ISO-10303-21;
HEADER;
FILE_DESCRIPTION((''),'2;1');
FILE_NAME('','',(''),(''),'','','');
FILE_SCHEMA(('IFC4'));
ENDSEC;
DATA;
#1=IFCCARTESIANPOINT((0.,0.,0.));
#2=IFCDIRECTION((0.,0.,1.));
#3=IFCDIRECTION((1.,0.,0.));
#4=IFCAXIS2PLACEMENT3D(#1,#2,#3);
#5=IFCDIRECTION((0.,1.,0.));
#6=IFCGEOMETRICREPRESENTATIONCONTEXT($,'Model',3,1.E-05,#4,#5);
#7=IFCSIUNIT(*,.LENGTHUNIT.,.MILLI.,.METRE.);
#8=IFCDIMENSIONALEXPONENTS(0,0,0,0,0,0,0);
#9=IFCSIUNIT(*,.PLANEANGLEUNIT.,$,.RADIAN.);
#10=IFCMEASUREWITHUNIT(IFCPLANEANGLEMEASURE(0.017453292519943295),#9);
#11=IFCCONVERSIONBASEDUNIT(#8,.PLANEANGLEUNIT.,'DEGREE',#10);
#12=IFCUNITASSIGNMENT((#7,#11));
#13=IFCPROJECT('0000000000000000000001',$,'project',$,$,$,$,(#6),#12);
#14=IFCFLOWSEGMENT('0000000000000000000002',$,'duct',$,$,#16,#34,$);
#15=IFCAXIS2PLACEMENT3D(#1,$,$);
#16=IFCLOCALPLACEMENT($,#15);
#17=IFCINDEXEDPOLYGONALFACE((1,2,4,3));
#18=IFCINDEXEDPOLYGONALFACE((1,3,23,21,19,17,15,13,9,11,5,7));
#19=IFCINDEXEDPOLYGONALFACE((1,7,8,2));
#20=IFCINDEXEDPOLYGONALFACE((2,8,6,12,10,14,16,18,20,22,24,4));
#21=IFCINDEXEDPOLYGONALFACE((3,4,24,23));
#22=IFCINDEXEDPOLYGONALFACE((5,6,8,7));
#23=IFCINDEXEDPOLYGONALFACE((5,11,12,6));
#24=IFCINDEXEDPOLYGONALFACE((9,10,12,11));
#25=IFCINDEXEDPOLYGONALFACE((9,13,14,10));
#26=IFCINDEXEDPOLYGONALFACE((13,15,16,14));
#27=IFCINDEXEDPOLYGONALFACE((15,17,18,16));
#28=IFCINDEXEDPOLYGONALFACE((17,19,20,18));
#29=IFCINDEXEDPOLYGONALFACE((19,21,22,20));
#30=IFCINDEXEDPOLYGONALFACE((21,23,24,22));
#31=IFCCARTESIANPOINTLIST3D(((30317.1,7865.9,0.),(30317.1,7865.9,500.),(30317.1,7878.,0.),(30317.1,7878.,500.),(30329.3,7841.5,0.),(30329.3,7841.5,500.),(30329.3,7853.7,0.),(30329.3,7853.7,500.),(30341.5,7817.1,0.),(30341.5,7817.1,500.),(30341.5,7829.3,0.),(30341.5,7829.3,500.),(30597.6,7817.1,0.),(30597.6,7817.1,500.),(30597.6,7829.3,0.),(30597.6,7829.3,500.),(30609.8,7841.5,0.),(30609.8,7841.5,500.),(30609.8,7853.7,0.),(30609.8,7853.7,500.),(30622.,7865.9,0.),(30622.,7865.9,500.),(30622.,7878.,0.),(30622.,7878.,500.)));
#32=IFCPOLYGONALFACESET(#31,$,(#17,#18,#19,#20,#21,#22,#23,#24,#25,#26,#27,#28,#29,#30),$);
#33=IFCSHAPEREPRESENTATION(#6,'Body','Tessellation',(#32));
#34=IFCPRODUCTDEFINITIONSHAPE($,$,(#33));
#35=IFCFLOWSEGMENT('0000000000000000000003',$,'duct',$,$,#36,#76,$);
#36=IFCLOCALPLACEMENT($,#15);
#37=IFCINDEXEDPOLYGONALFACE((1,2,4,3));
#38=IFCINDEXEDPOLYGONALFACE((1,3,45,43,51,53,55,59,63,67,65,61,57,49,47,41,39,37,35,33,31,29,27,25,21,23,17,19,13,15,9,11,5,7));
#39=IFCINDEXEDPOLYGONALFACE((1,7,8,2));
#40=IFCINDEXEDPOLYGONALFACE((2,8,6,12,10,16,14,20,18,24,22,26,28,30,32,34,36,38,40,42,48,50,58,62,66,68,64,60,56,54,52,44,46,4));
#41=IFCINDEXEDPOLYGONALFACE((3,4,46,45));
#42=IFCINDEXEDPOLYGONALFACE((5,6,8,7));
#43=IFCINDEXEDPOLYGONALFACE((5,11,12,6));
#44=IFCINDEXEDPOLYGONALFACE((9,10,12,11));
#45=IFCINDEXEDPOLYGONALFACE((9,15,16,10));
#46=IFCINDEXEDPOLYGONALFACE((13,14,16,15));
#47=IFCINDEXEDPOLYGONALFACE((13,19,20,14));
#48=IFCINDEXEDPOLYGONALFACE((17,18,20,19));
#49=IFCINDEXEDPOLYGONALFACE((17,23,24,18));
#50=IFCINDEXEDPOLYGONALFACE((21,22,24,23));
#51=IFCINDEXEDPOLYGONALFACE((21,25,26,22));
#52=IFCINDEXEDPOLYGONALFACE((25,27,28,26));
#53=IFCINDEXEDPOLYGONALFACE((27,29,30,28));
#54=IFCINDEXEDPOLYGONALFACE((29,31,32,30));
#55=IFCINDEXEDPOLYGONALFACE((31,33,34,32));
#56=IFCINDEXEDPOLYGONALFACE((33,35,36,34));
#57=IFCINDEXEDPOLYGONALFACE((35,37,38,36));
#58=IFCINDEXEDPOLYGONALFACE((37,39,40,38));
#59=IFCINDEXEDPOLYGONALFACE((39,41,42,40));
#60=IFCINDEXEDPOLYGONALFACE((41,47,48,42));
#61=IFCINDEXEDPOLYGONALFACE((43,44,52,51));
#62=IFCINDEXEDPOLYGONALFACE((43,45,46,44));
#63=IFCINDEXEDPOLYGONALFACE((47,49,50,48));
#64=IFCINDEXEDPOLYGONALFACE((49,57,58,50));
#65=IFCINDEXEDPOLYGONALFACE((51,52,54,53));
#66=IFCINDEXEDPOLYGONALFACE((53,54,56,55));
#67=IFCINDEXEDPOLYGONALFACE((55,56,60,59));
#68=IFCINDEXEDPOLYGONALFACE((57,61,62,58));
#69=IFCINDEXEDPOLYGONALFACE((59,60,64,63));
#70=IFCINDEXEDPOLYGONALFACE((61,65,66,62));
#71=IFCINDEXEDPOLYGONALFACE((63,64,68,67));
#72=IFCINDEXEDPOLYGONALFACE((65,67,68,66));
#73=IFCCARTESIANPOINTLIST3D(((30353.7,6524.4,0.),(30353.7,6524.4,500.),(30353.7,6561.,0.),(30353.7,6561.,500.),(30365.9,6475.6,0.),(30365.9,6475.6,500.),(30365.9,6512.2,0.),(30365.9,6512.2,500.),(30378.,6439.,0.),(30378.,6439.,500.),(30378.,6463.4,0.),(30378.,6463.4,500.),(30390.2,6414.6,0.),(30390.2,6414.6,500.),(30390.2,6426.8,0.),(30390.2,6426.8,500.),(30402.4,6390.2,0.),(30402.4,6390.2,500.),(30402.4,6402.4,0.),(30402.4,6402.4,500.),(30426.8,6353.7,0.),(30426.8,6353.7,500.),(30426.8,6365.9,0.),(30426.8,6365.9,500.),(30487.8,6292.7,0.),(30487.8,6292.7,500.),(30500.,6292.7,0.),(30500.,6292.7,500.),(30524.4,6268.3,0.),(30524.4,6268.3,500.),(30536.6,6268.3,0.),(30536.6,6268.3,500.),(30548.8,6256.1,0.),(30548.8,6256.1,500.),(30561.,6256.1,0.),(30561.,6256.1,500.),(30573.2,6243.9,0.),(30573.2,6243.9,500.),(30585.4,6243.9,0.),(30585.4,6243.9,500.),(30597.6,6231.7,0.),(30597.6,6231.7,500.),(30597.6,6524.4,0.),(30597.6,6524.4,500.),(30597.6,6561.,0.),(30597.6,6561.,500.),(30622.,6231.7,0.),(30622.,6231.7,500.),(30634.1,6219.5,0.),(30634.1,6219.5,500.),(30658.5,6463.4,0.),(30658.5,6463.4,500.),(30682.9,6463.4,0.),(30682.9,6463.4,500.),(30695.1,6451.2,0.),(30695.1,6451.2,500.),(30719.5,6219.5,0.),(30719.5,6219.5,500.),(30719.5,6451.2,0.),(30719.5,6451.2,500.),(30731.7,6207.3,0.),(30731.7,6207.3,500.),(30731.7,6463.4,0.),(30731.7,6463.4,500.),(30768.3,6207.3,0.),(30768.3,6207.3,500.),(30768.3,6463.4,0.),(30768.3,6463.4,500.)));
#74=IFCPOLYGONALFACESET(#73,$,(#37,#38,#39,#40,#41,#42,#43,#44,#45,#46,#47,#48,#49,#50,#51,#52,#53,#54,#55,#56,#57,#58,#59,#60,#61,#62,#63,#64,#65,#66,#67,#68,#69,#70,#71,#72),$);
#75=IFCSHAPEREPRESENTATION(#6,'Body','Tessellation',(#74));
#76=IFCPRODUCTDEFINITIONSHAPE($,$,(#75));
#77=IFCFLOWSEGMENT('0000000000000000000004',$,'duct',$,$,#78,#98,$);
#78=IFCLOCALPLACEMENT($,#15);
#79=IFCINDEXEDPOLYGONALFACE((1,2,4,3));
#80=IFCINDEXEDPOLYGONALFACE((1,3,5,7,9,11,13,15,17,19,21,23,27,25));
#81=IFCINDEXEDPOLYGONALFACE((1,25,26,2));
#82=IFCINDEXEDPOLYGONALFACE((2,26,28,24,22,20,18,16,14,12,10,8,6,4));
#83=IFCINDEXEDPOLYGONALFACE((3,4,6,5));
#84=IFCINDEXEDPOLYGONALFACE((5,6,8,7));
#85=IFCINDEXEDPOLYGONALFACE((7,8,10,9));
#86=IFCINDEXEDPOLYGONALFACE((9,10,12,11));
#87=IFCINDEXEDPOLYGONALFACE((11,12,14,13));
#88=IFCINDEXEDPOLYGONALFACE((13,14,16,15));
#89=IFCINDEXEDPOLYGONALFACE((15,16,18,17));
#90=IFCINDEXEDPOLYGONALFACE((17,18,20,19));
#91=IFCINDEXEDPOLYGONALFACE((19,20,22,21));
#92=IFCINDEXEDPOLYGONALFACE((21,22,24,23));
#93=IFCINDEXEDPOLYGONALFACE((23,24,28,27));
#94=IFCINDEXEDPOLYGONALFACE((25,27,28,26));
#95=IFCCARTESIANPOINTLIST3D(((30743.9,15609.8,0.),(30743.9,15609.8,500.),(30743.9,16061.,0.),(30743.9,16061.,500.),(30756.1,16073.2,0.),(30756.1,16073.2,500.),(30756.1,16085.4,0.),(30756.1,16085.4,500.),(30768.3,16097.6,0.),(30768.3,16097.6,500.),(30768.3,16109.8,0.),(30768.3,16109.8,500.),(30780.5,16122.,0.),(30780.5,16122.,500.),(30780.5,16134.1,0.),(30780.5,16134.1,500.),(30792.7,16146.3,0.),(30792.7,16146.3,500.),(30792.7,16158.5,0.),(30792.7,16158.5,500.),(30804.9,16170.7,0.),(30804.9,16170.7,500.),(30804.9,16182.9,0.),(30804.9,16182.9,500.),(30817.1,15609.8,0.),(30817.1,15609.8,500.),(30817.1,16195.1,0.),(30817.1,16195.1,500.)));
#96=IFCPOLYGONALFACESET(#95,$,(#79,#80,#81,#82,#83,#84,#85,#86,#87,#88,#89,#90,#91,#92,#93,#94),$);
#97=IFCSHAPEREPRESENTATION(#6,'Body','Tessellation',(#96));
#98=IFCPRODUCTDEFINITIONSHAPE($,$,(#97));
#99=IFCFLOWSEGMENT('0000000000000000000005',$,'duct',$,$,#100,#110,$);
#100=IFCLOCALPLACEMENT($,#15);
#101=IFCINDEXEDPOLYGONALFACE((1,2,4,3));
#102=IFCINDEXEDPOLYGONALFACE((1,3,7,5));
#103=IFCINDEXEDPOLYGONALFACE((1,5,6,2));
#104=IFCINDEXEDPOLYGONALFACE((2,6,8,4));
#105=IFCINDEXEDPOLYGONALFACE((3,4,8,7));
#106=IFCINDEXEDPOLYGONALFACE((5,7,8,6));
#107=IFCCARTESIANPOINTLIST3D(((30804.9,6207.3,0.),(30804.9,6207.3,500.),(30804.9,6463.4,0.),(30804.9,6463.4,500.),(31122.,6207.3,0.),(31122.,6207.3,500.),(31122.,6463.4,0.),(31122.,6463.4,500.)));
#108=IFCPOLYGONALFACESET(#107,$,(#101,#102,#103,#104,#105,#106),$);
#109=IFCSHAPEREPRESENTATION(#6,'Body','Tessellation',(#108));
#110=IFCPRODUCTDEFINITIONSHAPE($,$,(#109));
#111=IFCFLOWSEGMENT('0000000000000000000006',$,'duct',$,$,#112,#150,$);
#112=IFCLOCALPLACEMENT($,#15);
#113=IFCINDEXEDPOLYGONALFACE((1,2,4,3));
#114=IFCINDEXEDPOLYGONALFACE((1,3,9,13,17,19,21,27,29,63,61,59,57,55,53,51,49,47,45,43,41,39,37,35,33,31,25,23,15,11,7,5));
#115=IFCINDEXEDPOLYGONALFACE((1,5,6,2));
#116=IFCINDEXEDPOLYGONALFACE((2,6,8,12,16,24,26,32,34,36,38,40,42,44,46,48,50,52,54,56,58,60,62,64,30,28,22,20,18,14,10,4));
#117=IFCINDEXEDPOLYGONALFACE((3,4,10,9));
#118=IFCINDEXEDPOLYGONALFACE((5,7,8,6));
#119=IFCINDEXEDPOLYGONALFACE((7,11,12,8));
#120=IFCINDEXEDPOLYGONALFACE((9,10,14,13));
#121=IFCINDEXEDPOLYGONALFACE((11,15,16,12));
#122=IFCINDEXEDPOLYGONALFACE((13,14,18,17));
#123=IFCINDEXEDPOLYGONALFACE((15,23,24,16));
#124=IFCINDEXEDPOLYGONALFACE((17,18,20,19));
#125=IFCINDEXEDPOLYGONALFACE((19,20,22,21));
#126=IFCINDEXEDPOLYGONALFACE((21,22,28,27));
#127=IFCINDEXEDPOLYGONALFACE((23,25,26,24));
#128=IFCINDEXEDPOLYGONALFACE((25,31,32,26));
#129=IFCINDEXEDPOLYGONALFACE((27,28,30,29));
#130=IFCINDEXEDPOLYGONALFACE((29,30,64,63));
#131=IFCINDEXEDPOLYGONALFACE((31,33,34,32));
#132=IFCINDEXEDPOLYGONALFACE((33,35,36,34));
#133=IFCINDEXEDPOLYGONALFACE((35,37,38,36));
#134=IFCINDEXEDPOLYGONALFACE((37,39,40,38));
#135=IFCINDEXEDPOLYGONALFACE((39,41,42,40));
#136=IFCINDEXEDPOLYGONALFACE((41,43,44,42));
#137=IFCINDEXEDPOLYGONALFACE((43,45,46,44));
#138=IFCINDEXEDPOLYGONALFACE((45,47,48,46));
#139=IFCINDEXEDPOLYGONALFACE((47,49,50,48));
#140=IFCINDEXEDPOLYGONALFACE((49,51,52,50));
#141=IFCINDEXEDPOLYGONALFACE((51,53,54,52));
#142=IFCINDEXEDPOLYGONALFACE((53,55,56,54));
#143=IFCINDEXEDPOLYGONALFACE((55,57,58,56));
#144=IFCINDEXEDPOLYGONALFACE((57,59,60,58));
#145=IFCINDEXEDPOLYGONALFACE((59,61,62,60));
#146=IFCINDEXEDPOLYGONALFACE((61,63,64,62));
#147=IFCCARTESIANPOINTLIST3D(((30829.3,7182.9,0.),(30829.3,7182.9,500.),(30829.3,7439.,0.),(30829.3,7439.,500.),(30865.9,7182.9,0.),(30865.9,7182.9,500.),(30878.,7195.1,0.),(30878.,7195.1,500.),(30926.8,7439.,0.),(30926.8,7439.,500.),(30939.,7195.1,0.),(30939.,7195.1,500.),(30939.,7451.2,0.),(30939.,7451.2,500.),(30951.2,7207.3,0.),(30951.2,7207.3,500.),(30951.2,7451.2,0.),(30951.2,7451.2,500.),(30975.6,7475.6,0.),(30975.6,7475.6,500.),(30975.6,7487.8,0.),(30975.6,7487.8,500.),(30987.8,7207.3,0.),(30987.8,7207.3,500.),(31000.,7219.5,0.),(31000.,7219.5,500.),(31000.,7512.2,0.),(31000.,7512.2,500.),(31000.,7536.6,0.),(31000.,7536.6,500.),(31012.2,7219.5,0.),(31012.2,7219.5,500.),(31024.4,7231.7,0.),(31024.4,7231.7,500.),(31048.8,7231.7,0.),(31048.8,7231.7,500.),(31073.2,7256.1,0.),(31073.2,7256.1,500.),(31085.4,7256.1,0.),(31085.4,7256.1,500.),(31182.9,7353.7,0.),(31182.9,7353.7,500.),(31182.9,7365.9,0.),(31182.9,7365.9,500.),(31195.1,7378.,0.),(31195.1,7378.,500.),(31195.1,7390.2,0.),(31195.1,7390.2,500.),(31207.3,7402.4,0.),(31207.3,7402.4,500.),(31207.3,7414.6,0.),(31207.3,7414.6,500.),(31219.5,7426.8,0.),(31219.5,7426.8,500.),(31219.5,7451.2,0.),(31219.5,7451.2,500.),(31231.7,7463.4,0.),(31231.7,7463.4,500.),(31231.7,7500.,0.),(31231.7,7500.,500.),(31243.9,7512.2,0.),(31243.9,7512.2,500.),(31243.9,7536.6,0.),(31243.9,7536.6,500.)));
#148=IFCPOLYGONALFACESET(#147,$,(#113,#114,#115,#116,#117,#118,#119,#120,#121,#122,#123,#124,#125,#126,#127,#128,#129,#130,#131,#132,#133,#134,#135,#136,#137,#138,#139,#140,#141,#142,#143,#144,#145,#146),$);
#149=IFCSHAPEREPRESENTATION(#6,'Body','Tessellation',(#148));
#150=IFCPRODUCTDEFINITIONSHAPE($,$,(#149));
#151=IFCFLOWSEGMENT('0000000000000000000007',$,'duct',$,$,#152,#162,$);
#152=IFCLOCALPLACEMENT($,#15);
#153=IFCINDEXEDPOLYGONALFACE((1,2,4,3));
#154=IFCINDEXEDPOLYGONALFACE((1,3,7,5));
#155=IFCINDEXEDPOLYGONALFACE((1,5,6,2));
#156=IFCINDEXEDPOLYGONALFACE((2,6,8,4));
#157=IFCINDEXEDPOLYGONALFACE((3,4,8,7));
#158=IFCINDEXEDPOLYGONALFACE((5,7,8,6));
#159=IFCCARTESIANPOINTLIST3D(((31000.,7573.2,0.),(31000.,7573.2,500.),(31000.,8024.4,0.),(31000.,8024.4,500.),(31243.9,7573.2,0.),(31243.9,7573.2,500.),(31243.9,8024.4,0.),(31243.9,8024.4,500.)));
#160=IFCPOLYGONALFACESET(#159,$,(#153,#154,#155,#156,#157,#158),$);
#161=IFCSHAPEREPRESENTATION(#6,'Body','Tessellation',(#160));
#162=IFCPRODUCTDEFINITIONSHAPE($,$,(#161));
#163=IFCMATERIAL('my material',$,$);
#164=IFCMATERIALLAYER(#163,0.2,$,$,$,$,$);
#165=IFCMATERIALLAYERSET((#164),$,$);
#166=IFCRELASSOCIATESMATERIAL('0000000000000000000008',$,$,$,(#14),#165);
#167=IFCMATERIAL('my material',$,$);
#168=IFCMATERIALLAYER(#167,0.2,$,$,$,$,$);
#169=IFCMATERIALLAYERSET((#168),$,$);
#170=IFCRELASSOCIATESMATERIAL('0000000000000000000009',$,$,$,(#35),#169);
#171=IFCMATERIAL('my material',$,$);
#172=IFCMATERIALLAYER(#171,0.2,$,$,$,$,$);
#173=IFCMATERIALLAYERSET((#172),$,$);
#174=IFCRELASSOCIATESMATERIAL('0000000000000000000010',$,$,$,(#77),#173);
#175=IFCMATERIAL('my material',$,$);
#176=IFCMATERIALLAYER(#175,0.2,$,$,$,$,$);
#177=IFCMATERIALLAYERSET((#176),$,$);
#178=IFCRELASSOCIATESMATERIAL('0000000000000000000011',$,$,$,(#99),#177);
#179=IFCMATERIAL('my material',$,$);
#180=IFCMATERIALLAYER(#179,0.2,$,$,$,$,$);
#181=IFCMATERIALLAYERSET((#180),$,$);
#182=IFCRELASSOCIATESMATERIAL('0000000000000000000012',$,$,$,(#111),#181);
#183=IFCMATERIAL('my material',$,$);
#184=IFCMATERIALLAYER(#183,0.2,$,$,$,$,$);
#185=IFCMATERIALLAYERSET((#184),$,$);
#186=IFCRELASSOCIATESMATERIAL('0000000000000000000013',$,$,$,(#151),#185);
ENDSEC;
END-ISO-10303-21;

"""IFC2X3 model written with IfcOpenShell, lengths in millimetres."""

from ifc_helpers import new_model, entity, si_unit, converted_unit, direction, origin_with_axes, place, context, project, polyline, outline, extrude, material, layer, layer_set, layer_usage, element, save


model = new_model("IFC2X3")

# Units and contexts
model_context = context("Model", 3, precision=1e-05, world=origin_with_axes(), true_north=direction((0.0, 1.0, 0.0)))
ifc_project = project(units=[si_unit("LENGTHUNIT", "METRE", prefix="MILLI"), converted_unit("PLANEANGLEUNIT", "DEGREE", entity("IfcPlaneAngleMeasure", 0.017453292519943295), si_unit("PLANEANGLEUNIT", "RADIAN"), dimensions=[0, 0, 0, 0, 0, 0, 0])], contexts=[model_context])

# Flow segments
ifc_material_1 = material(Name="my material")
ifc_layer_1 = layer(ifc_material_1, 0.2)
ifc_layer_set_1 = layer_set([ifc_layer_1])
ifc_layer_usage_1 = layer_usage(ifc_layer_set_1, "AXIS2", "POSITIVE", -0.1)
flow_segment_1_placement = place(None, origin_with_axes())
element("IfcFlowSegment", 1, at=flow_segment_1_placement, material=ifc_layer_usage_1, Name="duct", context=model_context, shape_type="SweptSolid", body=[
    extrude(outline(polyline([(30317.1, 7865.9), (30329.3, 7853.7), (30329.3, 7841.5), (30341.5, 7829.3), (30341.5, 7817.1), (30597.6, 7817.1), (30597.6, 7829.3), (30609.8, 7841.5), (30609.8, 7853.7), (30622.0, 7865.9), (30622.0, 7878.0), (30317.1, 7878.0), (30317.1, 7865.9)])), origin_with_axes(), (0.0, 0.0, 1.0), 500.0),
])
ifc_material_2 = material(Name="my material")
ifc_layer_2 = layer(ifc_material_2, 0.2)
ifc_layer_set_2 = layer_set([ifc_layer_2])
ifc_layer_usage_2 = layer_usage(ifc_layer_set_2, "AXIS2", "POSITIVE", -0.1)
flow_segment_2_placement = place(None, origin_with_axes())
element("IfcFlowSegment", 2, at=flow_segment_2_placement, material=ifc_layer_usage_2, Name="duct", context=model_context, shape_type="SweptSolid", body=[
    extrude(outline(polyline([(30353.7, 6524.4), (30365.9, 6512.2), (30365.9, 6475.6), (30378.0, 6463.4), (30378.0, 6439.0), (30390.2, 6426.8), (30390.2, 6414.6), (30402.4, 6402.4), (30402.4, 6390.2), (30426.8, 6365.9), (30426.8, 6353.7), (30487.8, 6292.7), (30500.0, 6292.7), (30524.4, 6268.3), (30536.6, 6268.3), (30548.8, 6256.1), (30561.0, 6256.1), (30573.2, 6243.9), (30585.4, 6243.9), (30597.6, 6231.7), (30622.0, 6231.7), (30634.1, 6219.5), (30719.5, 6219.5), (30731.7, 6207.3), (30768.3, 6207.3), (30768.3, 6463.4), (30731.7, 6463.4), (30719.5, 6451.2), (30695.1, 6451.2), (30682.9, 6463.4), (30658.5, 6463.4), (30597.6, 6524.4), (30597.6, 6561.0), (30353.7, 6561.0), (30353.7, 6524.4)])), origin_with_axes(), (0.0, 0.0, 1.0), 500.0),
])
ifc_material_3 = material(Name="my material")
ifc_layer_3 = layer(ifc_material_3, 0.2)
ifc_layer_set_3 = layer_set([ifc_layer_3])
ifc_layer_usage_3 = layer_usage(ifc_layer_set_3, "AXIS2", "POSITIVE", -0.1)
flow_segment_3_placement = place(None, origin_with_axes())
element("IfcFlowSegment", 3, at=flow_segment_3_placement, material=ifc_layer_usage_3, Name="duct", context=model_context, shape_type="SweptSolid", body=[
    extrude(outline(polyline([(30743.9, 15609.8), (30817.1, 15609.8), (30817.1, 16207.3), (30817.1, 16195.1), (30804.9, 16182.9), (30804.9, 16170.7), (30792.7, 16158.5), (30792.7, 16146.3), (30780.5, 16134.1), (30780.5, 16122.0), (30768.3, 16109.8), (30768.3, 16097.6), (30756.1, 16085.4), (30756.1, 16073.2), (30743.9, 16061.0), (30743.9, 15609.8)])), origin_with_axes(), (0.0, 0.0, 1.0), 500.0),
])
ifc_material_4 = material(Name="my material")
ifc_layer_4 = layer(ifc_material_4, 0.2)
ifc_layer_set_4 = layer_set([ifc_layer_4])
ifc_layer_usage_4 = layer_usage(ifc_layer_set_4, "AXIS2", "POSITIVE", -0.1)
flow_segment_4_placement = place(None, origin_with_axes())
element("IfcFlowSegment", 4, at=flow_segment_4_placement, material=ifc_layer_usage_4, Name="duct", context=model_context, shape_type="SweptSolid", body=[
    extrude(outline(polyline([(30804.9, 6207.3), (31122.0, 6207.3), (31122.0, 6463.4), (30804.9, 6463.4), (30804.9, 6207.3)])), origin_with_axes(), (0.0, 0.0, 1.0), 500.0),
])
ifc_material_5 = material(Name="my material")
ifc_layer_5 = layer(ifc_material_5, 0.2)
ifc_layer_set_5 = layer_set([ifc_layer_5])
ifc_layer_usage_5 = layer_usage(ifc_layer_set_5, "AXIS2", "POSITIVE", -0.1)
flow_segment_5_placement = place(None, origin_with_axes())
element("IfcFlowSegment", 5, at=flow_segment_5_placement, material=ifc_layer_usage_5, Name="duct", context=model_context, shape_type="SweptSolid", body=[
    extrude(outline(polyline([(30829.3, 7182.9), (30865.9, 7182.9), (30878.0, 7195.1), (30939.0, 7195.1), (30951.2, 7207.3), (30987.8, 7207.3), (31000.0, 7219.5), (31012.2, 7219.5), (31024.4, 7231.7), (31048.8, 7231.7), (31073.2, 7256.1), (31085.4, 7256.1), (31182.9, 7353.7), (31182.9, 7365.9), (31195.1, 7378.0), (31195.1, 7390.2), (31207.3, 7402.4), (31207.3, 7414.6), (31219.5, 7426.8), (31219.5, 7451.2), (31231.7, 7463.4), (31231.7, 7500.0), (31243.9, 7512.2), (31243.9, 7536.6), (31000.0, 7536.6), (31000.0, 7512.2), (30975.6, 7487.8), (30975.6, 7475.6), (30951.2, 7451.2), (30939.0, 7451.2), (30926.8, 7439.0), (30829.3, 7439.0), (30829.3, 7182.9)])), origin_with_axes(), (0.0, 0.0, 1.0), 500.0),
])
ifc_material_6 = material(Name="my material")
ifc_layer_6 = layer(ifc_material_6, 0.2)
ifc_layer_set_6 = layer_set([ifc_layer_6])
ifc_layer_usage_6 = layer_usage(ifc_layer_set_6, "AXIS2", "POSITIVE", -0.1)
flow_segment_6_placement = place(None, origin_with_axes())
element("IfcFlowSegment", 6, at=flow_segment_6_placement, material=ifc_layer_usage_6, Name="duct", context=model_context, shape_type="SweptSolid", body=[
    extrude(outline(polyline([(31000.0, 7573.2), (31243.9, 7573.2), (31243.9, 8024.4), (31000.0, 8024.4), (31000.0, 7573.2)])), origin_with_axes(), (0.0, 0.0, 1.0), 500.0),
])

save(model, "model.ifc")
